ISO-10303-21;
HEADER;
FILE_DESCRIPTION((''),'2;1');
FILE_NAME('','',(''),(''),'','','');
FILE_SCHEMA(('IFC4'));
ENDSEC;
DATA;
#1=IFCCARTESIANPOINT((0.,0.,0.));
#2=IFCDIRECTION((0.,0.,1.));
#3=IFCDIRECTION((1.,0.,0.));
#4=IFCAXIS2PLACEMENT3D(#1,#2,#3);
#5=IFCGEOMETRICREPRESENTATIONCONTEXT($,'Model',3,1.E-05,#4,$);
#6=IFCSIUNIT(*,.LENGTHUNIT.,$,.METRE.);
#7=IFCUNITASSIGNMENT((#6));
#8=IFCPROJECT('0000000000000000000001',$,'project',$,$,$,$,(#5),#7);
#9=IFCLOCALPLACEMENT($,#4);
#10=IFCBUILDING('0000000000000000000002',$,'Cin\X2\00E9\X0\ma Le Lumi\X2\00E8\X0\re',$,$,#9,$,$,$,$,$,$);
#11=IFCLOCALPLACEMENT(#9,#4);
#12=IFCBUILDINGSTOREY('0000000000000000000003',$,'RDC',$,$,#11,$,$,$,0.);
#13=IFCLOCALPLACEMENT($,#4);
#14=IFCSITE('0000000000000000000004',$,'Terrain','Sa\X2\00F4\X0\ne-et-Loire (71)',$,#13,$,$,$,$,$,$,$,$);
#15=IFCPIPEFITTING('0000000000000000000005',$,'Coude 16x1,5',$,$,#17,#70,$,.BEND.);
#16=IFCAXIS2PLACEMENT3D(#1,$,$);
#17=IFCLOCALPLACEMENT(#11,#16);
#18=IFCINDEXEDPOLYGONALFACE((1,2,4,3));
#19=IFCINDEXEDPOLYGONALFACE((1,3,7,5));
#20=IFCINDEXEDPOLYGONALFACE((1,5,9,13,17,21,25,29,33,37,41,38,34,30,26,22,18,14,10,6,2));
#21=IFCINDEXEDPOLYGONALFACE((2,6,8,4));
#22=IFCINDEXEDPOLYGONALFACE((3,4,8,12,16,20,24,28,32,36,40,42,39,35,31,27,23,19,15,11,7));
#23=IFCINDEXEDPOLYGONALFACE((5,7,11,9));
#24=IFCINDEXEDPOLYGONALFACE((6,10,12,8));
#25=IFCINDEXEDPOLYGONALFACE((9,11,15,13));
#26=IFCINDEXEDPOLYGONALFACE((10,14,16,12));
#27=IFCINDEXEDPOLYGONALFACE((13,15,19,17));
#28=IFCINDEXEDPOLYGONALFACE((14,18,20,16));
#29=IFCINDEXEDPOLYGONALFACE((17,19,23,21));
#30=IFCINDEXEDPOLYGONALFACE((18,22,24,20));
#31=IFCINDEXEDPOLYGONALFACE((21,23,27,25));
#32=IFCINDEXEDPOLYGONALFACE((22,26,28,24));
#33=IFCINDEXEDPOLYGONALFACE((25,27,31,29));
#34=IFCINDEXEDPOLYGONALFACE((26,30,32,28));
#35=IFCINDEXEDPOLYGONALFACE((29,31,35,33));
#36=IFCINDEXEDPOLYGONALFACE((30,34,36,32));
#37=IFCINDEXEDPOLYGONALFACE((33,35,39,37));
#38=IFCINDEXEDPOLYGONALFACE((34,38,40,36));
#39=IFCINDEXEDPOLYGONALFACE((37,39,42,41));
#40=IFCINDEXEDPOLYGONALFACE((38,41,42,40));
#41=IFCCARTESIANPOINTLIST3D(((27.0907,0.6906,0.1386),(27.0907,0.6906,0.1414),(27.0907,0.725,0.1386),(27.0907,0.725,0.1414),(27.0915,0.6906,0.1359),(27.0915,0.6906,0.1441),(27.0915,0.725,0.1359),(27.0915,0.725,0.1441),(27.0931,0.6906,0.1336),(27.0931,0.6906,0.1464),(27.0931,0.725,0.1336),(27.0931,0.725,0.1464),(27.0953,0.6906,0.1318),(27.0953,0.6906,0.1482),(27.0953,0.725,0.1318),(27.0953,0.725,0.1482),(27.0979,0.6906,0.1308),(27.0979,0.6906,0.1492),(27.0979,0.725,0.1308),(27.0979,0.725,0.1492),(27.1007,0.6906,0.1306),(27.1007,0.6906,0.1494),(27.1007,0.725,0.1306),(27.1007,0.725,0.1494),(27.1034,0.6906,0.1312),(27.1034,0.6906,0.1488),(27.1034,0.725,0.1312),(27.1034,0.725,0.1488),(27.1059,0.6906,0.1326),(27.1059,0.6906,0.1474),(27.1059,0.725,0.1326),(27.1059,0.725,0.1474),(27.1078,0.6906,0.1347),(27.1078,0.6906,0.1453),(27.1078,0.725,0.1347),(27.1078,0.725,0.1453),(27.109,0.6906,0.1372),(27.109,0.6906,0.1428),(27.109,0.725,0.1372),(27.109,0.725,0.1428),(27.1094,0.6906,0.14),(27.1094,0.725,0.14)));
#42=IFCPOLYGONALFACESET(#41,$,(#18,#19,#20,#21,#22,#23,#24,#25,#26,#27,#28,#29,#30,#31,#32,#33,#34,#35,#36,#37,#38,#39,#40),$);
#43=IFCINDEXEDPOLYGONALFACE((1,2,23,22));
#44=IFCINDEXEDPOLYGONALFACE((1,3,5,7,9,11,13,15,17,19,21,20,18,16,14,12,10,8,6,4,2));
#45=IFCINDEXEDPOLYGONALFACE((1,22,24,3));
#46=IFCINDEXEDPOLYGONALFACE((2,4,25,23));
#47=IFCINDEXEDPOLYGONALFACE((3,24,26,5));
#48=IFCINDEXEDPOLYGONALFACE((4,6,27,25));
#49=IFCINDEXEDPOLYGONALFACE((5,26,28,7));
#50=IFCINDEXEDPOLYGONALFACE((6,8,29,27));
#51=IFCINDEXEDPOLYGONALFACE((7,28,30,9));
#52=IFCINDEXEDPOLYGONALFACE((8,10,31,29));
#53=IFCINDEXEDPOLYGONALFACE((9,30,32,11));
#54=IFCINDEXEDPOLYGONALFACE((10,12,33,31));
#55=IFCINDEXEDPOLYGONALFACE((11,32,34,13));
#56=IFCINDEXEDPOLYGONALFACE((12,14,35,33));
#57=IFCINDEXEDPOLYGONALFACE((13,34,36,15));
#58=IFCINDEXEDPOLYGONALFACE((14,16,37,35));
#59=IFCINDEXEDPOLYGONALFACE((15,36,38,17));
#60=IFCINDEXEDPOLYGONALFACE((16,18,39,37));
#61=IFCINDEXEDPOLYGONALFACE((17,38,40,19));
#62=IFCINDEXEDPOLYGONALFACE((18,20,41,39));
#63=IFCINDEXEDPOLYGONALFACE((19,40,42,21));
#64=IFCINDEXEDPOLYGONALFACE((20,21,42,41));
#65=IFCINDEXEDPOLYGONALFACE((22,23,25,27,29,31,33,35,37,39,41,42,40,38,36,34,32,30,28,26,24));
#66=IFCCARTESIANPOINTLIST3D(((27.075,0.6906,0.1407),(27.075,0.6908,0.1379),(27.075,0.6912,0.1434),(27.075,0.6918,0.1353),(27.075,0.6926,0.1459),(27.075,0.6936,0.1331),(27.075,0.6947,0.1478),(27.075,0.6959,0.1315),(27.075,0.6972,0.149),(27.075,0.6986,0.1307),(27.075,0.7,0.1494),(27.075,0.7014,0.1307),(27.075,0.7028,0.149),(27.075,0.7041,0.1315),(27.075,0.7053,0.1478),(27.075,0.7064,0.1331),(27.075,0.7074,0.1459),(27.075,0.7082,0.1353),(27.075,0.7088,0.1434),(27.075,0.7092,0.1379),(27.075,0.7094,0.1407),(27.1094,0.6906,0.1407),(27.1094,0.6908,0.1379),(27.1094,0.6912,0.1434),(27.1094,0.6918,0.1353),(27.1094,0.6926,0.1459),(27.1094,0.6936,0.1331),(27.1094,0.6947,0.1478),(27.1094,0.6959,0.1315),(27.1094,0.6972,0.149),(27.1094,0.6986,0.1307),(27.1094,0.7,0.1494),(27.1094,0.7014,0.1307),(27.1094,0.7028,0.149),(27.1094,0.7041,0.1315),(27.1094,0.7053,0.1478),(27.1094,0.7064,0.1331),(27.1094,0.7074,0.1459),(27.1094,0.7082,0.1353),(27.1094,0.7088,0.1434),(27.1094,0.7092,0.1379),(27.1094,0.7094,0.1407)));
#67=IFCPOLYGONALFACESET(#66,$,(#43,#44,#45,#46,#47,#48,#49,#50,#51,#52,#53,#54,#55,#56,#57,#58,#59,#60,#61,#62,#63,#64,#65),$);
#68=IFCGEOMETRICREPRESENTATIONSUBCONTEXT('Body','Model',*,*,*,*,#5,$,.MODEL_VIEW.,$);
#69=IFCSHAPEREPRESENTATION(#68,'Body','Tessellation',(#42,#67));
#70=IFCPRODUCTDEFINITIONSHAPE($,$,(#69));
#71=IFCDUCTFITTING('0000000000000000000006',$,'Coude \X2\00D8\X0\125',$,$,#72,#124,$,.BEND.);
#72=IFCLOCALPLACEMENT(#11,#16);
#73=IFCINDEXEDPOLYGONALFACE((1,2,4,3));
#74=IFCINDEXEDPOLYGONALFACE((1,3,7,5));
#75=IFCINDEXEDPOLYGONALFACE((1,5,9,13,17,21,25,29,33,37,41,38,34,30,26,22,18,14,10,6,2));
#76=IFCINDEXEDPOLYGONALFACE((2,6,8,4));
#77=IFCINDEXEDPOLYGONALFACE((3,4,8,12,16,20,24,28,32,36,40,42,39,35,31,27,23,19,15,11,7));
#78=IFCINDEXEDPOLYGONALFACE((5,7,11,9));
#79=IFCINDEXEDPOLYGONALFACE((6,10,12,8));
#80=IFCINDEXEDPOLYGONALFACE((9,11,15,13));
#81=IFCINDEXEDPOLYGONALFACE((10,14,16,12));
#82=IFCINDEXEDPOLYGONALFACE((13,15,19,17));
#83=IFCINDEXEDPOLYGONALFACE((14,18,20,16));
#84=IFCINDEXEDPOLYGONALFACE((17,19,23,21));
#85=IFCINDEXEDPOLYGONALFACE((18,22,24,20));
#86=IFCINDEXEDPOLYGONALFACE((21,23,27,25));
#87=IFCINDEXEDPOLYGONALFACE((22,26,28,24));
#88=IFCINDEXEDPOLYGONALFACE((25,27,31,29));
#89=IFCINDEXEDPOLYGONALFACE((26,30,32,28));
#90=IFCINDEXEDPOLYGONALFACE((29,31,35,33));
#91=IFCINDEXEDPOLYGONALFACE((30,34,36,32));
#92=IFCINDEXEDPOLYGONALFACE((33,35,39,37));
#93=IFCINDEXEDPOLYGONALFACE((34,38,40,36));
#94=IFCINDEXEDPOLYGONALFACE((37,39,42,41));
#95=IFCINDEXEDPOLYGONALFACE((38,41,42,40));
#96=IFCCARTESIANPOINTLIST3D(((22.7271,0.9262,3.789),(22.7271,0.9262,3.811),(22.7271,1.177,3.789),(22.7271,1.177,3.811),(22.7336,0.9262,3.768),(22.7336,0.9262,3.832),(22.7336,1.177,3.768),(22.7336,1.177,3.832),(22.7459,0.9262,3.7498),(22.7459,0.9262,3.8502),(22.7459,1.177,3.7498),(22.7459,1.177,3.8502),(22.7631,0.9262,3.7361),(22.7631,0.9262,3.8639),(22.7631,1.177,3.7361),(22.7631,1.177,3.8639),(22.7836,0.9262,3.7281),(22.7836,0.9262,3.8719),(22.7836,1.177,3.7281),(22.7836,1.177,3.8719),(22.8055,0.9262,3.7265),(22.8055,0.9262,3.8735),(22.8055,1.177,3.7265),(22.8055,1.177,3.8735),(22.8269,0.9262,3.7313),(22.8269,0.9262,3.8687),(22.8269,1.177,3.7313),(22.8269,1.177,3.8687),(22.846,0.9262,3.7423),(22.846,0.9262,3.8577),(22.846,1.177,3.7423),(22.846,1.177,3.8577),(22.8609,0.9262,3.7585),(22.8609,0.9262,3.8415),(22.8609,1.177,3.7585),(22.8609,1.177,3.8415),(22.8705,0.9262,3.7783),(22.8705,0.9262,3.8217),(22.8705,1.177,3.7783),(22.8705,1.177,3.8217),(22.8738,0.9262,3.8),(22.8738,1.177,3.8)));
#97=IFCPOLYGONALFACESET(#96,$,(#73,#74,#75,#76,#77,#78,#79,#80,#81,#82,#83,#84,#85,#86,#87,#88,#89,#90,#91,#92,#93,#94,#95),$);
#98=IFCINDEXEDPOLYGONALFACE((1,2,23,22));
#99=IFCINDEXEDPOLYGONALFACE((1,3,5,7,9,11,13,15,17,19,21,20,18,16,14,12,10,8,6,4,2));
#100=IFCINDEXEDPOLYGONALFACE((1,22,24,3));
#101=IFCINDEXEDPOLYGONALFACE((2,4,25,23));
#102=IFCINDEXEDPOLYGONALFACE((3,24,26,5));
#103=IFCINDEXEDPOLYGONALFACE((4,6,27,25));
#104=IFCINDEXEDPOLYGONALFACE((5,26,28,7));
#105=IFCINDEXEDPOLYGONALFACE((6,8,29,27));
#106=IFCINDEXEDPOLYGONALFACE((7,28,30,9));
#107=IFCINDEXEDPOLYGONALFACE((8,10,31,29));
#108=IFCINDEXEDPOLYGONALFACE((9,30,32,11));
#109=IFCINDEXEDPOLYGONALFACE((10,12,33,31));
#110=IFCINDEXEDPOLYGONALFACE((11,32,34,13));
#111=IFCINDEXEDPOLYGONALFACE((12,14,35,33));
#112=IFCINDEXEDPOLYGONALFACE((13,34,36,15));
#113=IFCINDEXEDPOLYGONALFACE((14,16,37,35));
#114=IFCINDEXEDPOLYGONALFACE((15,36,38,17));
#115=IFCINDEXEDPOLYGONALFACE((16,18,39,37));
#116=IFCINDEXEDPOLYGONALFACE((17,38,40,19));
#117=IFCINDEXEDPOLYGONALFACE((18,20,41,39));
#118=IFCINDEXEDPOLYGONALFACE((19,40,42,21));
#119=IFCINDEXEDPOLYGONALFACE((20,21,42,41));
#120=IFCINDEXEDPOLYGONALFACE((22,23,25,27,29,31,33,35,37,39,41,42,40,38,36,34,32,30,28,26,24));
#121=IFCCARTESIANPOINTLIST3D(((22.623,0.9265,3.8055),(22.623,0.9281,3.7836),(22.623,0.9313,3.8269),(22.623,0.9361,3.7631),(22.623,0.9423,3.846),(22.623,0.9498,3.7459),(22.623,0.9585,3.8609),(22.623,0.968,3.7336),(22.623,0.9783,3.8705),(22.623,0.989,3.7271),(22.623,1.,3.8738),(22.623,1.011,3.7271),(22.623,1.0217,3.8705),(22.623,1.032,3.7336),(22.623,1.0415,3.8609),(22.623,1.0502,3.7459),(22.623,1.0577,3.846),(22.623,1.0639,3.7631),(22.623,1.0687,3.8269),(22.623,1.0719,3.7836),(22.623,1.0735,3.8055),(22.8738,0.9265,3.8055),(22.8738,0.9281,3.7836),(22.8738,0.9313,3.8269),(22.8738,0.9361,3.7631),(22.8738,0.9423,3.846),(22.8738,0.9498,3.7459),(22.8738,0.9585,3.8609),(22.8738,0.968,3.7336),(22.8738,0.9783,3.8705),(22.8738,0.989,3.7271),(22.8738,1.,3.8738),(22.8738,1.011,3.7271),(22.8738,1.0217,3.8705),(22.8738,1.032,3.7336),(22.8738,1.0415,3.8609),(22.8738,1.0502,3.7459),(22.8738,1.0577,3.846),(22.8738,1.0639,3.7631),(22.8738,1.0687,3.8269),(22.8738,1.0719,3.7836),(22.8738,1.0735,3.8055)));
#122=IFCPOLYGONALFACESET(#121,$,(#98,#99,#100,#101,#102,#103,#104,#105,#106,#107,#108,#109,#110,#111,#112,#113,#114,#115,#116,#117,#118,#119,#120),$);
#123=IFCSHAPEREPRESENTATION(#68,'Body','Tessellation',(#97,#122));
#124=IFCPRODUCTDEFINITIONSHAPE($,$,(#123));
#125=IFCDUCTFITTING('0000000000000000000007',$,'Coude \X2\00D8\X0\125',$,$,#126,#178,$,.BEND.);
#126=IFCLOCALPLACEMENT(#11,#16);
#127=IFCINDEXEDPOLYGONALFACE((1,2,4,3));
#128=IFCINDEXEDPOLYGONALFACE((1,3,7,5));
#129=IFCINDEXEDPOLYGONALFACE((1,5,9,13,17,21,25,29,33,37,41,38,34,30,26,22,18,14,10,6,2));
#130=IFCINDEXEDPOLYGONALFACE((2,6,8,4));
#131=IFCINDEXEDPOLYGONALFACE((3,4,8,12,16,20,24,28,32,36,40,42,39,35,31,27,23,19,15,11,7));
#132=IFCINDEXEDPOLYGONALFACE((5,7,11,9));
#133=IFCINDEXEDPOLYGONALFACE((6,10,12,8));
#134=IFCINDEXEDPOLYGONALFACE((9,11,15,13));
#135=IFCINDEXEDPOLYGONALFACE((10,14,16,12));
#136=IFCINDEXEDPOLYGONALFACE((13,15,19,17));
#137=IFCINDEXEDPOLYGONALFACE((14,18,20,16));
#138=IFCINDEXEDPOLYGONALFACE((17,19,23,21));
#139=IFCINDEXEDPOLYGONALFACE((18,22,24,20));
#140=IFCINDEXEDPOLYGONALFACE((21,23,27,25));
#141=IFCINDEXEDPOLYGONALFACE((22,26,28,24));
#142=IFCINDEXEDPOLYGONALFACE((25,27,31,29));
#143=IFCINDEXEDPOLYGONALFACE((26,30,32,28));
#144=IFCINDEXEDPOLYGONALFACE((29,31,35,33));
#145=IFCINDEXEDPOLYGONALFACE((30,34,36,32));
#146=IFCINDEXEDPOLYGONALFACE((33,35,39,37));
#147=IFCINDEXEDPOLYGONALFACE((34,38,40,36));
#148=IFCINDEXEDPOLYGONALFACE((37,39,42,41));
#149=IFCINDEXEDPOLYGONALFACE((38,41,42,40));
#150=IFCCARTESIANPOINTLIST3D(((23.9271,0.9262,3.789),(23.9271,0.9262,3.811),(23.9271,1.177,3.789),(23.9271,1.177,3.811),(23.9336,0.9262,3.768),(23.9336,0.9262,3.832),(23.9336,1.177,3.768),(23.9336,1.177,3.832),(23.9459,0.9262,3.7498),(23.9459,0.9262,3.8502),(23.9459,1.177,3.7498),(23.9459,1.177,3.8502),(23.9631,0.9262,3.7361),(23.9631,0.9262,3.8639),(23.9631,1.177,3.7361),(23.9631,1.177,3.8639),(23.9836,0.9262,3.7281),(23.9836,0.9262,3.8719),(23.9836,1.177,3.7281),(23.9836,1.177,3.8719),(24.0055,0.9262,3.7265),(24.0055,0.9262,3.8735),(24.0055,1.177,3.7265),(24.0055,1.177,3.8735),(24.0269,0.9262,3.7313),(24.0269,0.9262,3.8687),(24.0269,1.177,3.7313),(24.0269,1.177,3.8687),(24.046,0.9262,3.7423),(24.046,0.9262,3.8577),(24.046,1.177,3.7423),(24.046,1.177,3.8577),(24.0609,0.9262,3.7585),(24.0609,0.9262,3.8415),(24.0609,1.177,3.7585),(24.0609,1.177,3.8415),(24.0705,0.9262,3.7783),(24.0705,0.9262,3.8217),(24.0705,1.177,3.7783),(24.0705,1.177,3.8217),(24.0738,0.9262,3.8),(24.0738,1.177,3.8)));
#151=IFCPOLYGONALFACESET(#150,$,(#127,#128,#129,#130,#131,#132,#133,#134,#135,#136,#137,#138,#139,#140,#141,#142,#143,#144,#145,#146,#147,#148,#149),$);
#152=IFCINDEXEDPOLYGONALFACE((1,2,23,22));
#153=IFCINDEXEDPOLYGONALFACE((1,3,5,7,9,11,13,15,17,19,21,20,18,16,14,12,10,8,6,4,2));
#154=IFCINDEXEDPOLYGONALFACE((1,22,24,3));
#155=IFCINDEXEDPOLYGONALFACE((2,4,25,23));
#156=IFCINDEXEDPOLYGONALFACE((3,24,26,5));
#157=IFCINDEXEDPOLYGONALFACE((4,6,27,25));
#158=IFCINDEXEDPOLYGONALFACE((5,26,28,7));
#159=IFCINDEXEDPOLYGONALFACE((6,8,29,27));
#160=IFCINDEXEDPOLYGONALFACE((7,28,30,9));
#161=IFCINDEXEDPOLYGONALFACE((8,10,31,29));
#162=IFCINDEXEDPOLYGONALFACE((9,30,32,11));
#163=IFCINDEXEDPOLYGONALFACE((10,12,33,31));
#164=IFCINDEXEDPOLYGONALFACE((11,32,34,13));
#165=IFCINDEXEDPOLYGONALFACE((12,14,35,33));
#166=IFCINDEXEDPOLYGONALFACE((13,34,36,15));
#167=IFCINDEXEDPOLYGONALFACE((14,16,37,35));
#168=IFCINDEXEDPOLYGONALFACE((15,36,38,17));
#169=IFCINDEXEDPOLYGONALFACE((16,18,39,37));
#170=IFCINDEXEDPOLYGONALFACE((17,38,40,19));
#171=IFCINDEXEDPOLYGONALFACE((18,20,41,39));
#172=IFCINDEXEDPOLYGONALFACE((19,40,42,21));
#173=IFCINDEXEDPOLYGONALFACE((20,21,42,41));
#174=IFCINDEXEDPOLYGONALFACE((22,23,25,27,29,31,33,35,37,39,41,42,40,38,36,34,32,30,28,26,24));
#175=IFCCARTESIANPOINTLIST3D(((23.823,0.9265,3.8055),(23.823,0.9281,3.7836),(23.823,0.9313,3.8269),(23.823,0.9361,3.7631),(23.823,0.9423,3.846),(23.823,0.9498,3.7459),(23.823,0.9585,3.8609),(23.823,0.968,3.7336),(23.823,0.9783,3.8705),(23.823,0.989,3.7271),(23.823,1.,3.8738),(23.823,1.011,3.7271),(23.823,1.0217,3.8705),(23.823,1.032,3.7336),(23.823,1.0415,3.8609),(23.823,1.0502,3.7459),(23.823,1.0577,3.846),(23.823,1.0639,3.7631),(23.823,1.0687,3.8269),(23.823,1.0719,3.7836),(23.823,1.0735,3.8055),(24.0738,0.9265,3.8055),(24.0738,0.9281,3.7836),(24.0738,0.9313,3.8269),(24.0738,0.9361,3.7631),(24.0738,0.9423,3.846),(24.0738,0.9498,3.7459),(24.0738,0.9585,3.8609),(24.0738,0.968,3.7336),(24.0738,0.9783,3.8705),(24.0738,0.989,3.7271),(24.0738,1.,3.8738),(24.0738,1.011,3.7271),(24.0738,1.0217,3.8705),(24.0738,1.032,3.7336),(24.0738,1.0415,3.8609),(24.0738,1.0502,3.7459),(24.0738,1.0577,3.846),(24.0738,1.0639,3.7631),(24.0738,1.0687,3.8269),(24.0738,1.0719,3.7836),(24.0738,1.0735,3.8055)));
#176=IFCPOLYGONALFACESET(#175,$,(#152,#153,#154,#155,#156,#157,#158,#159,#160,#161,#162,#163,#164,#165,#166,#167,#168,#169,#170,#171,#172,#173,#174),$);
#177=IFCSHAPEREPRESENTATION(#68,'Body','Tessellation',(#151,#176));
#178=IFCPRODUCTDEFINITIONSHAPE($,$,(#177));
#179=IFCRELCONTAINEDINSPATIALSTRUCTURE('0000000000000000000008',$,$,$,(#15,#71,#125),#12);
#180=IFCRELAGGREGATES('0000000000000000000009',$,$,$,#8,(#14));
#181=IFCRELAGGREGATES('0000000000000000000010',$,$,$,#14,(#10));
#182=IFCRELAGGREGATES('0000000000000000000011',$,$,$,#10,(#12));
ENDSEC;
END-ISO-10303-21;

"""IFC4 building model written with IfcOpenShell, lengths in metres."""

from ifc_helpers import new_model, si_unit, frame, origin_with_axes, place, context, subcontext, project, spatial, circle, extrude, element, save


model = new_model("IFC4")

# Units and contexts
model_context = context("Model", 3, precision=1e-05, world=origin_with_axes())
body_context = subcontext(model_context, "Body", "Model", "MODEL_VIEW")
ifc_project = project(units=[si_unit("LENGTHUNIT", "METRE")], contexts=[model_context])

# Site, building, storey
site_placement = place(None, origin_with_axes())
site = spatial("IfcSite", under=ifc_project, at=site_placement, Name="Terrain", Description="Saône-et-Loire (71)")
building_placement = place(None, origin_with_axes())
building = spatial("IfcBuilding", under=site, at=building_placement, Name="Cinéma Le Lumière")
storey_placement = place(building_placement, origin_with_axes())
storey = spatial("IfcBuildingStorey", under=building, at=storey_placement, Name="RDC", Elevation=0.0)

# Pipe fitting
for number, where, z_axis, x_axis, name in (
    (1, (27.1, 0.7, 0.14), (0.0, 0.0, 1.0), (1.0, 0.0, 0.0), "Coude 16x1,5"),
):
    element("IfcPipeFitting", number, at=place(storey_placement, frame(where, z_axis=z_axis, x_axis=x_axis)), inside=storey, Name=name, PredefinedType="BEND", context=body_context, shape_type="SweptSolid", body=[
        extrude(circle(Radius=0.0094), frame((0.0, -0.0094, 0.0), z_axis=(0.0, 1.0, 0.0), x_axis=(1.0, 0.0, 0.0)), (0.0, 0.0, 1.0), 0.0344),
        extrude(circle(Radius=0.0094), frame((0.0094, 0.0, 0.0), z_axis=(-1.0, 0.0, 0.0), x_axis=(0.0, 0.0, 1.0)), (0.0, 0.0, 1.0), 0.0344),
    ])

# Duct fittings
for number, where, z_axis, x_axis, name in (
    (2, (22.8, 1.0, 3.8), (0.0, 0.0, 1.0), (1.0, 0.0, 0.0), "Coude Ø125"),
    (3, (24.0, 1.0, 3.8), (0.0, 0.0, 1.0), (1.0, 0.0, 0.0), "Coude Ø125"),
):
    element("IfcDuctFitting", number, at=place(storey_placement, frame(where, z_axis=z_axis, x_axis=x_axis)), inside=storey, Name=name, PredefinedType="BEND", context=body_context, shape_type="SweptSolid", body=[
        extrude(circle(Radius=0.0737), frame((0.0, -0.0737, 0.0), z_axis=(0.0, 1.0, 0.0), x_axis=(1.0, 0.0, 0.0)), (0.0, 0.0, 1.0), 0.2507),
        extrude(circle(Radius=0.0737), frame((0.0737, 0.0, 0.0), z_axis=(-1.0, 0.0, 0.0), x_axis=(0.0, 0.0, 1.0)), (0.0, 0.0, 1.0), 0.2507),
    ])

save(model, "model.ifc")
